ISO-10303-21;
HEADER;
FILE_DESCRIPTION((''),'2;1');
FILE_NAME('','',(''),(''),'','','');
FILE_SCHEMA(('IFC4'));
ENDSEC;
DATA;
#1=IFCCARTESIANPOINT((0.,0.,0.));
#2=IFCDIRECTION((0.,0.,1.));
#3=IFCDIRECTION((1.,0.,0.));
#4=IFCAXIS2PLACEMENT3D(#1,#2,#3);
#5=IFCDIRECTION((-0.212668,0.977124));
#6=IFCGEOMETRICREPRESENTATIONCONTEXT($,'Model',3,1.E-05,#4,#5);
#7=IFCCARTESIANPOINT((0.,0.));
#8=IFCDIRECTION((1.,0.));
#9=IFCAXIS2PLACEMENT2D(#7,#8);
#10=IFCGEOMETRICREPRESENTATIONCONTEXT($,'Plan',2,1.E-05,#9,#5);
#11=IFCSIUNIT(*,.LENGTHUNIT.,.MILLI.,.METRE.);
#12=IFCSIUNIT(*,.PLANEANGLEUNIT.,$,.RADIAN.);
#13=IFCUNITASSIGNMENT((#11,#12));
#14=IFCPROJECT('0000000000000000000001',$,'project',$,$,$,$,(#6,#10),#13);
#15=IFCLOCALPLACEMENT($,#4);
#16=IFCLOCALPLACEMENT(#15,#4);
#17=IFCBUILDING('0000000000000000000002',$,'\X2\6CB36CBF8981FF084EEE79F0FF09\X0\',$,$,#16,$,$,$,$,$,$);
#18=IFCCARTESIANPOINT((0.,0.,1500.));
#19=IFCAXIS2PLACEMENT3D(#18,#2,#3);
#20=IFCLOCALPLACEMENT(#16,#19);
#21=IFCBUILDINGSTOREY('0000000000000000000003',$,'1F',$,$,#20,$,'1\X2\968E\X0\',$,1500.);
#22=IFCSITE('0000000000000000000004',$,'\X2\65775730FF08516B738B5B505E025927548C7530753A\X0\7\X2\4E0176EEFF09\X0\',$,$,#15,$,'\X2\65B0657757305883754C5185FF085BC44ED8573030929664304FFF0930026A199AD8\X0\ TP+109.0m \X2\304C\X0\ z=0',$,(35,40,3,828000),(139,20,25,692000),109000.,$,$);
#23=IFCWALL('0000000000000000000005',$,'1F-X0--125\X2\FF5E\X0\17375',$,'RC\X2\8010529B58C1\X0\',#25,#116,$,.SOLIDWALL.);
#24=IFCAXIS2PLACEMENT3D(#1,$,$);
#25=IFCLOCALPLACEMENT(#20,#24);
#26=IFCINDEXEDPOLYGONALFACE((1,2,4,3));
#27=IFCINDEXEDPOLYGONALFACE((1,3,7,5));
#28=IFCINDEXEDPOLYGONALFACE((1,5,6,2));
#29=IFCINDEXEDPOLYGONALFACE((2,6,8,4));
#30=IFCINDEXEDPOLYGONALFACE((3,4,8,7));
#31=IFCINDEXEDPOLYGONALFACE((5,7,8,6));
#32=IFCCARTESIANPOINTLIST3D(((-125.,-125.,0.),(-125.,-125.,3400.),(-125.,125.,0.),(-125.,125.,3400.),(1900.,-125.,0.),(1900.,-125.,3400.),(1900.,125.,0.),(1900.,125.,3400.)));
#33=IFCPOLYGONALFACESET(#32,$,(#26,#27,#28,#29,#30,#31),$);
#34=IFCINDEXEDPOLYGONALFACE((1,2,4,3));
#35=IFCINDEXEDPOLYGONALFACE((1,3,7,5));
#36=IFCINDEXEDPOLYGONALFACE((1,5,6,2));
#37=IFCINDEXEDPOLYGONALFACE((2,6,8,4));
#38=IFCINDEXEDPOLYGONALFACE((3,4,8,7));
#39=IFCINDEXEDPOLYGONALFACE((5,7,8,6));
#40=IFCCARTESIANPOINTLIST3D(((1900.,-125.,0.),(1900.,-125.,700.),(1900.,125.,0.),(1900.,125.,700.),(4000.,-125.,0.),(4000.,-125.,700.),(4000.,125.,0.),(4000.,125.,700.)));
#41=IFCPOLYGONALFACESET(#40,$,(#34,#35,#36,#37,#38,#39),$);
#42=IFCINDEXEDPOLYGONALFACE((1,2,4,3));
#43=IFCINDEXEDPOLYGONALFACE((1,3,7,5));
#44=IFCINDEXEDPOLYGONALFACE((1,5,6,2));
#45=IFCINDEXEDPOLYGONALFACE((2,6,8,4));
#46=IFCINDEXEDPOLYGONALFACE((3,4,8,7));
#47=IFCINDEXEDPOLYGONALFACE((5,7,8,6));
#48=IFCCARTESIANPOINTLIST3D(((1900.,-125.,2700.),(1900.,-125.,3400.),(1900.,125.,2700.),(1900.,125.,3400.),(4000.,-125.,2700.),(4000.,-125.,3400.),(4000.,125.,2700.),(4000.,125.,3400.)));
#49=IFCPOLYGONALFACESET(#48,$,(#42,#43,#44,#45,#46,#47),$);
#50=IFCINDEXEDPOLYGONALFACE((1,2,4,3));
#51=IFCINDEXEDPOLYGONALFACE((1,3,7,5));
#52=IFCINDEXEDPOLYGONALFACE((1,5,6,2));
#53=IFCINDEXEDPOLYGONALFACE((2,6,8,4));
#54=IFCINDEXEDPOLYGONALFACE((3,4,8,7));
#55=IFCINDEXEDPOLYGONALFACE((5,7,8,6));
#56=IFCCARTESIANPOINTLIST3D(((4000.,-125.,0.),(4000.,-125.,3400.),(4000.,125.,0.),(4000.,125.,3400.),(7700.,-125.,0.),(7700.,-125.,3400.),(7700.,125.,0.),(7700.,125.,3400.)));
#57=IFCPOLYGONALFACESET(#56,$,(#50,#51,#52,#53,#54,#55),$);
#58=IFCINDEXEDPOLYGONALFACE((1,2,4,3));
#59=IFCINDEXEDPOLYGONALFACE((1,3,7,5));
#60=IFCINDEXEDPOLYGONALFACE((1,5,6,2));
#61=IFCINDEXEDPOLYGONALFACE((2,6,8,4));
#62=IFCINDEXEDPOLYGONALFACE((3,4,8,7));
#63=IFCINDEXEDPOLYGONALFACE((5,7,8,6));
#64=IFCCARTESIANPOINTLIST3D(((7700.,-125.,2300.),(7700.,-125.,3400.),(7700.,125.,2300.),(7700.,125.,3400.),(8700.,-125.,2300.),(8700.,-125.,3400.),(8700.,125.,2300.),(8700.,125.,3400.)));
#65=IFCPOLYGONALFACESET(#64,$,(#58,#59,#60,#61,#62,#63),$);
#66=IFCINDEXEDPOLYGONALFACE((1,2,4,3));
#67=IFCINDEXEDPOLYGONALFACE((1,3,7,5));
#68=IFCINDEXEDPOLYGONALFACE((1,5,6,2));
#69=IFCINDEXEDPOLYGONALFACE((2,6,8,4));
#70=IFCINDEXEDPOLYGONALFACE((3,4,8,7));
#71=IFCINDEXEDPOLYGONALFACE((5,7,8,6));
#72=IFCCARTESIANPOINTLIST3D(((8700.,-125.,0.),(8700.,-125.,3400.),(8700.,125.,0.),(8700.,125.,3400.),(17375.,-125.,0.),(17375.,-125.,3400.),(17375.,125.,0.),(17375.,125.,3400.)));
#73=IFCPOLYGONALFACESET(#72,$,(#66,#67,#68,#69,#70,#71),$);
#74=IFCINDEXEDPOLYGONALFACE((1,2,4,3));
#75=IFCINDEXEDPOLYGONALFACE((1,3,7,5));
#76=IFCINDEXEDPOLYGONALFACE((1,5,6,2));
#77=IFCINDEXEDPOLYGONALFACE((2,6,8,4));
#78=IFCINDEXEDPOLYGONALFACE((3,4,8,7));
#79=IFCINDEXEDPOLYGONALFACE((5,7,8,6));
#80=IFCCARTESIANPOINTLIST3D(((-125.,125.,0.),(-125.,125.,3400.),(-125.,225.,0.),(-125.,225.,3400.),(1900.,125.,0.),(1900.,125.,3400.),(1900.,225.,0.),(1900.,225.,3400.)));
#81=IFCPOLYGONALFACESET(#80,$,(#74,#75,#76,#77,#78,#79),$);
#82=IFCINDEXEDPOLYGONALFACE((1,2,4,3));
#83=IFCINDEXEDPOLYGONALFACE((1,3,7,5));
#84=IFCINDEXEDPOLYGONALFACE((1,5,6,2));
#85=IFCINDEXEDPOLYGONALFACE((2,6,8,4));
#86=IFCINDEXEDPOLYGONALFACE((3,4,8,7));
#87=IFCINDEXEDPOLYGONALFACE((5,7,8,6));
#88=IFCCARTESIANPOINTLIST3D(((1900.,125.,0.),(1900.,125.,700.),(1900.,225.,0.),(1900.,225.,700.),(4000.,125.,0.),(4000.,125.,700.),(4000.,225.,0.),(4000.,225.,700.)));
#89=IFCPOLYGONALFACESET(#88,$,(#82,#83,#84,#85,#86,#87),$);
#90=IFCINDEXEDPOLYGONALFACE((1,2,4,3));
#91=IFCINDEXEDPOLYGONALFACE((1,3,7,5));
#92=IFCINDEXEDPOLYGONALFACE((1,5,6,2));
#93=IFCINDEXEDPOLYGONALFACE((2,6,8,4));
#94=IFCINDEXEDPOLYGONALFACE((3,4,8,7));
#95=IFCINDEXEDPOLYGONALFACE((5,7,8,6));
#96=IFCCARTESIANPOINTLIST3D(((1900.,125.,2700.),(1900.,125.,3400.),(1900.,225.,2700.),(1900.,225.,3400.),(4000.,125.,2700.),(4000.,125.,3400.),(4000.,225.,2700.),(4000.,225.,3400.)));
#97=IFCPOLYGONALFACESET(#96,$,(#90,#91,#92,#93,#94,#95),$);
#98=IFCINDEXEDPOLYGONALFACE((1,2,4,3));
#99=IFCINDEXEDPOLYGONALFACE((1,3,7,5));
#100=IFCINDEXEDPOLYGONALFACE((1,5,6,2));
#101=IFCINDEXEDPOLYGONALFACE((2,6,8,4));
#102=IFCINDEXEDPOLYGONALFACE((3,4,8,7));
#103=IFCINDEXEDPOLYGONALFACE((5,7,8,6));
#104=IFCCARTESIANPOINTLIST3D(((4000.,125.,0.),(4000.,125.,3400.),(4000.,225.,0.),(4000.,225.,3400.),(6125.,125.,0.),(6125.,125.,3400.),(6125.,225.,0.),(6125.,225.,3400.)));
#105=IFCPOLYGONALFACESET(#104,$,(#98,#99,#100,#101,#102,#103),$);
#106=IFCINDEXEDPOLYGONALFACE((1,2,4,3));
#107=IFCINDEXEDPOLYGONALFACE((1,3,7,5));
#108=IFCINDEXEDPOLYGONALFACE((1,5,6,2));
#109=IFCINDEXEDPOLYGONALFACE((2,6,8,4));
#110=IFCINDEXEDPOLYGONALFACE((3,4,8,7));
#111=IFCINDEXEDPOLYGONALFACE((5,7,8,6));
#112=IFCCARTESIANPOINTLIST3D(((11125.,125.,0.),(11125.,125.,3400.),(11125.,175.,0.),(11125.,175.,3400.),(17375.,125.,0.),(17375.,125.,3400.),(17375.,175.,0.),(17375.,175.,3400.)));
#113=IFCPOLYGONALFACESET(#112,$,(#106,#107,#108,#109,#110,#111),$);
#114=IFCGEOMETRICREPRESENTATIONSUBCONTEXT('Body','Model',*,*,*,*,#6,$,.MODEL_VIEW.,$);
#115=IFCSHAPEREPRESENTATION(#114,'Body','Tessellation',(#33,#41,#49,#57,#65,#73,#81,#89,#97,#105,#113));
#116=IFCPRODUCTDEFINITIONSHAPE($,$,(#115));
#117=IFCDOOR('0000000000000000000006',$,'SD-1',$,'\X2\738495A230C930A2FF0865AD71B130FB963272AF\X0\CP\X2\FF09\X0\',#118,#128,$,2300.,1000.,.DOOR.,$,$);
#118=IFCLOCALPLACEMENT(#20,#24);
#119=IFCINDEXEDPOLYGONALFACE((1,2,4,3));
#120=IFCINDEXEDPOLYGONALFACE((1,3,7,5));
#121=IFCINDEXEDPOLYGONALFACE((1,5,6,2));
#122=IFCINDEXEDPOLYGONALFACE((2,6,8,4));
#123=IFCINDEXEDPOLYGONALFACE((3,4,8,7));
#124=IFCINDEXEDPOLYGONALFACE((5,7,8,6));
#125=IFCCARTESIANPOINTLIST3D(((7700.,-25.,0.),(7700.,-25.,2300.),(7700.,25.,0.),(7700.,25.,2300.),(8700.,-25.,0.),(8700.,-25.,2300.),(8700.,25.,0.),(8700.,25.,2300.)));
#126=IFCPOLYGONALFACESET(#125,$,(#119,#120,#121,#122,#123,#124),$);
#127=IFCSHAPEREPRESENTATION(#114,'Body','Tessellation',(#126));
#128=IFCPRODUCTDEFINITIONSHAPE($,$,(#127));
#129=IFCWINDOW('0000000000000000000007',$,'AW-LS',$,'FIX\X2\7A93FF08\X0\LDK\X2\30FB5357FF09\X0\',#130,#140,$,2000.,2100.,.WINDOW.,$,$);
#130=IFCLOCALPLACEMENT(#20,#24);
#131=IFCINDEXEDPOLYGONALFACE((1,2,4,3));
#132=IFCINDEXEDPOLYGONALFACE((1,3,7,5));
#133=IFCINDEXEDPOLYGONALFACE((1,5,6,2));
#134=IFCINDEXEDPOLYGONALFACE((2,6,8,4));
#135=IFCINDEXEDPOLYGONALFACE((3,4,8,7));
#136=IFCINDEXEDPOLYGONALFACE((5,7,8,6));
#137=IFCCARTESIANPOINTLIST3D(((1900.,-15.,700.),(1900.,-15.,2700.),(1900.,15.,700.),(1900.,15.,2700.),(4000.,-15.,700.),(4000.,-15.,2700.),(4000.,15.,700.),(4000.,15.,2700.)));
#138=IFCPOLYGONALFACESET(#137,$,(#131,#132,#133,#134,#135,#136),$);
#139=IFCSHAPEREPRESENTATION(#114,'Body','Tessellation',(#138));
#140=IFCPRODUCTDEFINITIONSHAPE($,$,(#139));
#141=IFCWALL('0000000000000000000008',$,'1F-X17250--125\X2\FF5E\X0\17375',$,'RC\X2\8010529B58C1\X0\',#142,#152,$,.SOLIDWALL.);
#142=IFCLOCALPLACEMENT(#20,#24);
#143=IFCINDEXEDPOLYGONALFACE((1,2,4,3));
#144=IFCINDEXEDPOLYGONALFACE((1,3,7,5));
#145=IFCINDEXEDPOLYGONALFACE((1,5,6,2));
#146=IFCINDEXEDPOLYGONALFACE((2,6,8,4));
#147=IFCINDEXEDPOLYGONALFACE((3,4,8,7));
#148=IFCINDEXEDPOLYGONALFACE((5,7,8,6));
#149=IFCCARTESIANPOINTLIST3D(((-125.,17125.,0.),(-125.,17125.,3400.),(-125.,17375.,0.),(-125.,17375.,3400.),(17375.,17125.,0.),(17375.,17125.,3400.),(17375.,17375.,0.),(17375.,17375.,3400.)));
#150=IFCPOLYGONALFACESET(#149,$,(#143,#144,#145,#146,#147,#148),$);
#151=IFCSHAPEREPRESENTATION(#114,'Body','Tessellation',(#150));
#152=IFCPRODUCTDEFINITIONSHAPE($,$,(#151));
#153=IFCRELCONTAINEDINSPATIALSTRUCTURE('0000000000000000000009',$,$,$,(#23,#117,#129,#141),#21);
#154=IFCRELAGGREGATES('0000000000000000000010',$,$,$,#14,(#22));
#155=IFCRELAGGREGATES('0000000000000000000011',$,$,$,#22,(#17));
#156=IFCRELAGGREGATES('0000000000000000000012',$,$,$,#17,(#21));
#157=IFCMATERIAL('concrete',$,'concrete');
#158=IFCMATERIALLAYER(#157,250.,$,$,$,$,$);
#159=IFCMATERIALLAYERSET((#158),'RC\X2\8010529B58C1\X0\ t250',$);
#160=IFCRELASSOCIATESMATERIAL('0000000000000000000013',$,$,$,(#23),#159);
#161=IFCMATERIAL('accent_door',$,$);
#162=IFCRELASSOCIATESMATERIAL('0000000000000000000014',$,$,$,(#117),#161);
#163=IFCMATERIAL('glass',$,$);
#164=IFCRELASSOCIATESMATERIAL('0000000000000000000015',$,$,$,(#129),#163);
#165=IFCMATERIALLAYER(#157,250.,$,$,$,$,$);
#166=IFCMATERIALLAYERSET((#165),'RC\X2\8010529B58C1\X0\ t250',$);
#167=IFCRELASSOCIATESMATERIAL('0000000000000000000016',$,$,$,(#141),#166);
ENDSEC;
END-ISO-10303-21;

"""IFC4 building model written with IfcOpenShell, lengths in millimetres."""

from ifc_helpers import new_model, si_unit, direction, frame, frame_2d, origin, origin_with_axes, origin_2d_with_axis, place, context, subcontext, project, spatial, rectangle, extrude, material, layer, layer_set, layer_usage, element, fill, save


model = new_model("IFC4")

# Units and contexts
model_context = context("Model", 3, precision=1e-05, world=origin_with_axes(), true_north=direction((-0.212668, 0.977124)))
plan_context = context("Plan", 2, precision=1e-05, world=origin_2d_with_axis(), true_north=direction((-0.212668, 0.977124)))
body_context = subcontext(model_context, "Body", "Model", "MODEL_VIEW")
ifc_project = project(units=[si_unit("LENGTHUNIT", "METRE", prefix="MILLI"), si_unit("PLANEANGLEUNIT", "RADIAN")], contexts=[model_context, plan_context])

# Site, building, storey
site_placement = place(None, origin_with_axes())
site = spatial("IfcSite", under=ifc_project, at=site_placement, Name="敷地（八王子市大和田町7丁目）", LongName="新敷地境界内（寄付地を除く）。標高 TP+109.0m が z=0", RefLatitude=(35, 40, 3, 828000), RefLongitude=(139, 20, 25, 692000), RefElevation=109000.0)
building_placement = place(site_placement, origin_with_axes())
building = spatial("IfcBuilding", under=site, at=building_placement, Name="河沿要（仮称）")
storey_placement = place(building_placement, frame((0.0, 0.0, 1500.0), z_axis=(0.0, 0.0, 1.0), x_axis=(1.0, 0.0, 0.0)))
storey = spatial("IfcBuildingStorey", under=building, at=storey_placement, Name="1F", LongName="1階", Elevation=1500.0)

# Wall, openings, door, window
ifc_material_1 = material(Name="concrete", Category="concrete")
ifc_layer_1 = layer(ifc_material_1, 250.0)
ifc_layer_set_1 = layer_set([ifc_layer_1], Name="RC耐力壁 t250")
ifc_layer_usage_1 = layer_usage(ifc_layer_set_1, "AXIS2", "POSITIVE", 0.0)
wall_1_placement = place(storey_placement, origin_with_axes())
wall_1 = element("IfcWall", 1, at=wall_1_placement, inside=storey, material=ifc_layer_usage_1, Name="1F-X0--125～17375", ObjectType="RC耐力壁", PredefinedType="SOLIDWALL", context=body_context, shape_type="SweptSolid", body=[
    extrude(rectangle(XDim=2025.0, YDim=250.0, at=frame_2d((887.5, 0.0))), origin(), (0.0, 0.0, 1.0), 3400.0),
    extrude(rectangle(XDim=2100.0, YDim=250.0, at=frame_2d((2950.0, 0.0))), origin(), (0.0, 0.0, 1.0), 700.0),
    extrude(rectangle(XDim=2100.0, YDim=250.0, at=frame_2d((2950.0, 0.0))), frame((0.0, 0.0, 2700.0)), (0.0, 0.0, 1.0), 700.0),
    extrude(rectangle(XDim=3700.0, YDim=250.0, at=frame_2d((5850.0, 0.0))), origin(), (0.0, 0.0, 1.0), 3400.0),
    extrude(rectangle(XDim=1000.0, YDim=250.0, at=frame_2d((8200.0, 0.0))), frame((0.0, 0.0, 2300.0)), (0.0, 0.0, 1.0), 1100.0),
    extrude(rectangle(XDim=8675.0, YDim=250.0, at=frame_2d((13037.5, 0.0))), origin(), (0.0, 0.0, 1.0), 3400.0),
    extrude(rectangle(XDim=2025.0, YDim=100.0, at=frame_2d((887.5, 175.0))), origin(), (0.0, 0.0, 1.0), 3400.0),
    extrude(rectangle(XDim=2100.0, YDim=100.0, at=frame_2d((2950.0, 175.0))), origin(), (0.0, 0.0, 1.0), 700.0),
    extrude(rectangle(XDim=2100.0, YDim=100.0, at=frame_2d((2950.0, 175.0))), frame((0.0, 0.0, 2700.0)), (0.0, 0.0, 1.0), 700.0),
    extrude(rectangle(XDim=2125.0, YDim=100.0, at=frame_2d((5062.5, 175.0))), origin(), (0.0, 0.0, 1.0), 3400.0),
    extrude(rectangle(XDim=6250.0, YDim=50.0, at=frame_2d((14250.0, 150.0))), origin(), (0.0, 0.0, 1.0), 3400.0),
])
opening_1_placement = place(storey_placement, origin_with_axes())
opening_1 = element("IfcOpeningElement", 2, at=opening_1_placement, inside=storey, cuts=wall_1, PredefinedType="OPENING", context=body_context, shape_type="SweptSolid", body=[
    extrude(rectangle(XDim=1000.0, YDim=300.0, at=frame_2d((8200.0, 0.0))), origin(), (0.0, 0.0, 1.0), 2300.0),
])
opening_2_placement = place(storey_placement, origin_with_axes())
opening_2 = element("IfcOpeningElement", 3, at=opening_2_placement, inside=storey, cuts=wall_1, PredefinedType="OPENING", context=body_context, shape_type="SweptSolid", body=[
    extrude(rectangle(XDim=2100.0, YDim=300.0, at=frame_2d((2950.0, 0.0))), frame((0.0, 0.0, 700.0)), (0.0, 0.0, 1.0), 2000.0),
])
ifc_material_2 = material(Name="accent_door")
door_1_placement = place(storey_placement, origin_with_axes())
door_1 = element("IfcDoor", 4, at=door_1_placement, inside=storey, material=ifc_material_2, Name="SD-1", ObjectType="玄関ドア（断熱・防犯CP）", OverallHeight=2300.0, OverallWidth=1000.0, PredefinedType="DOOR", context=body_context, shape_type="SweptSolid", body=[
    extrude(rectangle(XDim=1000.0, YDim=50.0, at=frame_2d((8200.0, 0.0))), origin(), (0.0, 0.0, 1.0), 2300.0),
])
fill(opening_1, door_1)
ifc_material_3 = material(Name="glass")
window_1_placement = place(storey_placement, origin_with_axes())
window_1 = element("IfcWindow", 5, at=window_1_placement, inside=storey, material=ifc_material_3, Name="AW-LS", ObjectType="FIX窓（LDK・南）", OverallHeight=2000.0, OverallWidth=2100.0, PredefinedType="WINDOW", context=body_context, shape_type="SweptSolid", body=[
    extrude(rectangle(XDim=2100.0, YDim=30.0, at=frame_2d((2950.0, 0.0))), frame((0.0, 0.0, 700.0)), (0.0, 0.0, 1.0), 2000.0),
])
fill(opening_2, window_1)

# Wall
ifc_layer_2 = layer(ifc_material_1, 250.0)
ifc_layer_set_2 = layer_set([ifc_layer_2], Name="RC耐力壁 t250")
ifc_layer_usage_2 = layer_usage(ifc_layer_set_2, "AXIS2", "POSITIVE", 0.0)
wall_2_placement = place(storey_placement, origin_with_axes())
element("IfcWall", 6, at=wall_2_placement, inside=storey, material=ifc_layer_usage_2, Name="1F-X17250--125～17375", ObjectType="RC耐力壁", PredefinedType="SOLIDWALL", context=body_context, shape_type="SweptSolid", body=[
    extrude(rectangle(XDim=17500.0, YDim=250.0, at=frame_2d((8625.0, 17250.0))), origin(), (0.0, 0.0, 1.0), 3400.0),
])

save(model, "model.ifc")
